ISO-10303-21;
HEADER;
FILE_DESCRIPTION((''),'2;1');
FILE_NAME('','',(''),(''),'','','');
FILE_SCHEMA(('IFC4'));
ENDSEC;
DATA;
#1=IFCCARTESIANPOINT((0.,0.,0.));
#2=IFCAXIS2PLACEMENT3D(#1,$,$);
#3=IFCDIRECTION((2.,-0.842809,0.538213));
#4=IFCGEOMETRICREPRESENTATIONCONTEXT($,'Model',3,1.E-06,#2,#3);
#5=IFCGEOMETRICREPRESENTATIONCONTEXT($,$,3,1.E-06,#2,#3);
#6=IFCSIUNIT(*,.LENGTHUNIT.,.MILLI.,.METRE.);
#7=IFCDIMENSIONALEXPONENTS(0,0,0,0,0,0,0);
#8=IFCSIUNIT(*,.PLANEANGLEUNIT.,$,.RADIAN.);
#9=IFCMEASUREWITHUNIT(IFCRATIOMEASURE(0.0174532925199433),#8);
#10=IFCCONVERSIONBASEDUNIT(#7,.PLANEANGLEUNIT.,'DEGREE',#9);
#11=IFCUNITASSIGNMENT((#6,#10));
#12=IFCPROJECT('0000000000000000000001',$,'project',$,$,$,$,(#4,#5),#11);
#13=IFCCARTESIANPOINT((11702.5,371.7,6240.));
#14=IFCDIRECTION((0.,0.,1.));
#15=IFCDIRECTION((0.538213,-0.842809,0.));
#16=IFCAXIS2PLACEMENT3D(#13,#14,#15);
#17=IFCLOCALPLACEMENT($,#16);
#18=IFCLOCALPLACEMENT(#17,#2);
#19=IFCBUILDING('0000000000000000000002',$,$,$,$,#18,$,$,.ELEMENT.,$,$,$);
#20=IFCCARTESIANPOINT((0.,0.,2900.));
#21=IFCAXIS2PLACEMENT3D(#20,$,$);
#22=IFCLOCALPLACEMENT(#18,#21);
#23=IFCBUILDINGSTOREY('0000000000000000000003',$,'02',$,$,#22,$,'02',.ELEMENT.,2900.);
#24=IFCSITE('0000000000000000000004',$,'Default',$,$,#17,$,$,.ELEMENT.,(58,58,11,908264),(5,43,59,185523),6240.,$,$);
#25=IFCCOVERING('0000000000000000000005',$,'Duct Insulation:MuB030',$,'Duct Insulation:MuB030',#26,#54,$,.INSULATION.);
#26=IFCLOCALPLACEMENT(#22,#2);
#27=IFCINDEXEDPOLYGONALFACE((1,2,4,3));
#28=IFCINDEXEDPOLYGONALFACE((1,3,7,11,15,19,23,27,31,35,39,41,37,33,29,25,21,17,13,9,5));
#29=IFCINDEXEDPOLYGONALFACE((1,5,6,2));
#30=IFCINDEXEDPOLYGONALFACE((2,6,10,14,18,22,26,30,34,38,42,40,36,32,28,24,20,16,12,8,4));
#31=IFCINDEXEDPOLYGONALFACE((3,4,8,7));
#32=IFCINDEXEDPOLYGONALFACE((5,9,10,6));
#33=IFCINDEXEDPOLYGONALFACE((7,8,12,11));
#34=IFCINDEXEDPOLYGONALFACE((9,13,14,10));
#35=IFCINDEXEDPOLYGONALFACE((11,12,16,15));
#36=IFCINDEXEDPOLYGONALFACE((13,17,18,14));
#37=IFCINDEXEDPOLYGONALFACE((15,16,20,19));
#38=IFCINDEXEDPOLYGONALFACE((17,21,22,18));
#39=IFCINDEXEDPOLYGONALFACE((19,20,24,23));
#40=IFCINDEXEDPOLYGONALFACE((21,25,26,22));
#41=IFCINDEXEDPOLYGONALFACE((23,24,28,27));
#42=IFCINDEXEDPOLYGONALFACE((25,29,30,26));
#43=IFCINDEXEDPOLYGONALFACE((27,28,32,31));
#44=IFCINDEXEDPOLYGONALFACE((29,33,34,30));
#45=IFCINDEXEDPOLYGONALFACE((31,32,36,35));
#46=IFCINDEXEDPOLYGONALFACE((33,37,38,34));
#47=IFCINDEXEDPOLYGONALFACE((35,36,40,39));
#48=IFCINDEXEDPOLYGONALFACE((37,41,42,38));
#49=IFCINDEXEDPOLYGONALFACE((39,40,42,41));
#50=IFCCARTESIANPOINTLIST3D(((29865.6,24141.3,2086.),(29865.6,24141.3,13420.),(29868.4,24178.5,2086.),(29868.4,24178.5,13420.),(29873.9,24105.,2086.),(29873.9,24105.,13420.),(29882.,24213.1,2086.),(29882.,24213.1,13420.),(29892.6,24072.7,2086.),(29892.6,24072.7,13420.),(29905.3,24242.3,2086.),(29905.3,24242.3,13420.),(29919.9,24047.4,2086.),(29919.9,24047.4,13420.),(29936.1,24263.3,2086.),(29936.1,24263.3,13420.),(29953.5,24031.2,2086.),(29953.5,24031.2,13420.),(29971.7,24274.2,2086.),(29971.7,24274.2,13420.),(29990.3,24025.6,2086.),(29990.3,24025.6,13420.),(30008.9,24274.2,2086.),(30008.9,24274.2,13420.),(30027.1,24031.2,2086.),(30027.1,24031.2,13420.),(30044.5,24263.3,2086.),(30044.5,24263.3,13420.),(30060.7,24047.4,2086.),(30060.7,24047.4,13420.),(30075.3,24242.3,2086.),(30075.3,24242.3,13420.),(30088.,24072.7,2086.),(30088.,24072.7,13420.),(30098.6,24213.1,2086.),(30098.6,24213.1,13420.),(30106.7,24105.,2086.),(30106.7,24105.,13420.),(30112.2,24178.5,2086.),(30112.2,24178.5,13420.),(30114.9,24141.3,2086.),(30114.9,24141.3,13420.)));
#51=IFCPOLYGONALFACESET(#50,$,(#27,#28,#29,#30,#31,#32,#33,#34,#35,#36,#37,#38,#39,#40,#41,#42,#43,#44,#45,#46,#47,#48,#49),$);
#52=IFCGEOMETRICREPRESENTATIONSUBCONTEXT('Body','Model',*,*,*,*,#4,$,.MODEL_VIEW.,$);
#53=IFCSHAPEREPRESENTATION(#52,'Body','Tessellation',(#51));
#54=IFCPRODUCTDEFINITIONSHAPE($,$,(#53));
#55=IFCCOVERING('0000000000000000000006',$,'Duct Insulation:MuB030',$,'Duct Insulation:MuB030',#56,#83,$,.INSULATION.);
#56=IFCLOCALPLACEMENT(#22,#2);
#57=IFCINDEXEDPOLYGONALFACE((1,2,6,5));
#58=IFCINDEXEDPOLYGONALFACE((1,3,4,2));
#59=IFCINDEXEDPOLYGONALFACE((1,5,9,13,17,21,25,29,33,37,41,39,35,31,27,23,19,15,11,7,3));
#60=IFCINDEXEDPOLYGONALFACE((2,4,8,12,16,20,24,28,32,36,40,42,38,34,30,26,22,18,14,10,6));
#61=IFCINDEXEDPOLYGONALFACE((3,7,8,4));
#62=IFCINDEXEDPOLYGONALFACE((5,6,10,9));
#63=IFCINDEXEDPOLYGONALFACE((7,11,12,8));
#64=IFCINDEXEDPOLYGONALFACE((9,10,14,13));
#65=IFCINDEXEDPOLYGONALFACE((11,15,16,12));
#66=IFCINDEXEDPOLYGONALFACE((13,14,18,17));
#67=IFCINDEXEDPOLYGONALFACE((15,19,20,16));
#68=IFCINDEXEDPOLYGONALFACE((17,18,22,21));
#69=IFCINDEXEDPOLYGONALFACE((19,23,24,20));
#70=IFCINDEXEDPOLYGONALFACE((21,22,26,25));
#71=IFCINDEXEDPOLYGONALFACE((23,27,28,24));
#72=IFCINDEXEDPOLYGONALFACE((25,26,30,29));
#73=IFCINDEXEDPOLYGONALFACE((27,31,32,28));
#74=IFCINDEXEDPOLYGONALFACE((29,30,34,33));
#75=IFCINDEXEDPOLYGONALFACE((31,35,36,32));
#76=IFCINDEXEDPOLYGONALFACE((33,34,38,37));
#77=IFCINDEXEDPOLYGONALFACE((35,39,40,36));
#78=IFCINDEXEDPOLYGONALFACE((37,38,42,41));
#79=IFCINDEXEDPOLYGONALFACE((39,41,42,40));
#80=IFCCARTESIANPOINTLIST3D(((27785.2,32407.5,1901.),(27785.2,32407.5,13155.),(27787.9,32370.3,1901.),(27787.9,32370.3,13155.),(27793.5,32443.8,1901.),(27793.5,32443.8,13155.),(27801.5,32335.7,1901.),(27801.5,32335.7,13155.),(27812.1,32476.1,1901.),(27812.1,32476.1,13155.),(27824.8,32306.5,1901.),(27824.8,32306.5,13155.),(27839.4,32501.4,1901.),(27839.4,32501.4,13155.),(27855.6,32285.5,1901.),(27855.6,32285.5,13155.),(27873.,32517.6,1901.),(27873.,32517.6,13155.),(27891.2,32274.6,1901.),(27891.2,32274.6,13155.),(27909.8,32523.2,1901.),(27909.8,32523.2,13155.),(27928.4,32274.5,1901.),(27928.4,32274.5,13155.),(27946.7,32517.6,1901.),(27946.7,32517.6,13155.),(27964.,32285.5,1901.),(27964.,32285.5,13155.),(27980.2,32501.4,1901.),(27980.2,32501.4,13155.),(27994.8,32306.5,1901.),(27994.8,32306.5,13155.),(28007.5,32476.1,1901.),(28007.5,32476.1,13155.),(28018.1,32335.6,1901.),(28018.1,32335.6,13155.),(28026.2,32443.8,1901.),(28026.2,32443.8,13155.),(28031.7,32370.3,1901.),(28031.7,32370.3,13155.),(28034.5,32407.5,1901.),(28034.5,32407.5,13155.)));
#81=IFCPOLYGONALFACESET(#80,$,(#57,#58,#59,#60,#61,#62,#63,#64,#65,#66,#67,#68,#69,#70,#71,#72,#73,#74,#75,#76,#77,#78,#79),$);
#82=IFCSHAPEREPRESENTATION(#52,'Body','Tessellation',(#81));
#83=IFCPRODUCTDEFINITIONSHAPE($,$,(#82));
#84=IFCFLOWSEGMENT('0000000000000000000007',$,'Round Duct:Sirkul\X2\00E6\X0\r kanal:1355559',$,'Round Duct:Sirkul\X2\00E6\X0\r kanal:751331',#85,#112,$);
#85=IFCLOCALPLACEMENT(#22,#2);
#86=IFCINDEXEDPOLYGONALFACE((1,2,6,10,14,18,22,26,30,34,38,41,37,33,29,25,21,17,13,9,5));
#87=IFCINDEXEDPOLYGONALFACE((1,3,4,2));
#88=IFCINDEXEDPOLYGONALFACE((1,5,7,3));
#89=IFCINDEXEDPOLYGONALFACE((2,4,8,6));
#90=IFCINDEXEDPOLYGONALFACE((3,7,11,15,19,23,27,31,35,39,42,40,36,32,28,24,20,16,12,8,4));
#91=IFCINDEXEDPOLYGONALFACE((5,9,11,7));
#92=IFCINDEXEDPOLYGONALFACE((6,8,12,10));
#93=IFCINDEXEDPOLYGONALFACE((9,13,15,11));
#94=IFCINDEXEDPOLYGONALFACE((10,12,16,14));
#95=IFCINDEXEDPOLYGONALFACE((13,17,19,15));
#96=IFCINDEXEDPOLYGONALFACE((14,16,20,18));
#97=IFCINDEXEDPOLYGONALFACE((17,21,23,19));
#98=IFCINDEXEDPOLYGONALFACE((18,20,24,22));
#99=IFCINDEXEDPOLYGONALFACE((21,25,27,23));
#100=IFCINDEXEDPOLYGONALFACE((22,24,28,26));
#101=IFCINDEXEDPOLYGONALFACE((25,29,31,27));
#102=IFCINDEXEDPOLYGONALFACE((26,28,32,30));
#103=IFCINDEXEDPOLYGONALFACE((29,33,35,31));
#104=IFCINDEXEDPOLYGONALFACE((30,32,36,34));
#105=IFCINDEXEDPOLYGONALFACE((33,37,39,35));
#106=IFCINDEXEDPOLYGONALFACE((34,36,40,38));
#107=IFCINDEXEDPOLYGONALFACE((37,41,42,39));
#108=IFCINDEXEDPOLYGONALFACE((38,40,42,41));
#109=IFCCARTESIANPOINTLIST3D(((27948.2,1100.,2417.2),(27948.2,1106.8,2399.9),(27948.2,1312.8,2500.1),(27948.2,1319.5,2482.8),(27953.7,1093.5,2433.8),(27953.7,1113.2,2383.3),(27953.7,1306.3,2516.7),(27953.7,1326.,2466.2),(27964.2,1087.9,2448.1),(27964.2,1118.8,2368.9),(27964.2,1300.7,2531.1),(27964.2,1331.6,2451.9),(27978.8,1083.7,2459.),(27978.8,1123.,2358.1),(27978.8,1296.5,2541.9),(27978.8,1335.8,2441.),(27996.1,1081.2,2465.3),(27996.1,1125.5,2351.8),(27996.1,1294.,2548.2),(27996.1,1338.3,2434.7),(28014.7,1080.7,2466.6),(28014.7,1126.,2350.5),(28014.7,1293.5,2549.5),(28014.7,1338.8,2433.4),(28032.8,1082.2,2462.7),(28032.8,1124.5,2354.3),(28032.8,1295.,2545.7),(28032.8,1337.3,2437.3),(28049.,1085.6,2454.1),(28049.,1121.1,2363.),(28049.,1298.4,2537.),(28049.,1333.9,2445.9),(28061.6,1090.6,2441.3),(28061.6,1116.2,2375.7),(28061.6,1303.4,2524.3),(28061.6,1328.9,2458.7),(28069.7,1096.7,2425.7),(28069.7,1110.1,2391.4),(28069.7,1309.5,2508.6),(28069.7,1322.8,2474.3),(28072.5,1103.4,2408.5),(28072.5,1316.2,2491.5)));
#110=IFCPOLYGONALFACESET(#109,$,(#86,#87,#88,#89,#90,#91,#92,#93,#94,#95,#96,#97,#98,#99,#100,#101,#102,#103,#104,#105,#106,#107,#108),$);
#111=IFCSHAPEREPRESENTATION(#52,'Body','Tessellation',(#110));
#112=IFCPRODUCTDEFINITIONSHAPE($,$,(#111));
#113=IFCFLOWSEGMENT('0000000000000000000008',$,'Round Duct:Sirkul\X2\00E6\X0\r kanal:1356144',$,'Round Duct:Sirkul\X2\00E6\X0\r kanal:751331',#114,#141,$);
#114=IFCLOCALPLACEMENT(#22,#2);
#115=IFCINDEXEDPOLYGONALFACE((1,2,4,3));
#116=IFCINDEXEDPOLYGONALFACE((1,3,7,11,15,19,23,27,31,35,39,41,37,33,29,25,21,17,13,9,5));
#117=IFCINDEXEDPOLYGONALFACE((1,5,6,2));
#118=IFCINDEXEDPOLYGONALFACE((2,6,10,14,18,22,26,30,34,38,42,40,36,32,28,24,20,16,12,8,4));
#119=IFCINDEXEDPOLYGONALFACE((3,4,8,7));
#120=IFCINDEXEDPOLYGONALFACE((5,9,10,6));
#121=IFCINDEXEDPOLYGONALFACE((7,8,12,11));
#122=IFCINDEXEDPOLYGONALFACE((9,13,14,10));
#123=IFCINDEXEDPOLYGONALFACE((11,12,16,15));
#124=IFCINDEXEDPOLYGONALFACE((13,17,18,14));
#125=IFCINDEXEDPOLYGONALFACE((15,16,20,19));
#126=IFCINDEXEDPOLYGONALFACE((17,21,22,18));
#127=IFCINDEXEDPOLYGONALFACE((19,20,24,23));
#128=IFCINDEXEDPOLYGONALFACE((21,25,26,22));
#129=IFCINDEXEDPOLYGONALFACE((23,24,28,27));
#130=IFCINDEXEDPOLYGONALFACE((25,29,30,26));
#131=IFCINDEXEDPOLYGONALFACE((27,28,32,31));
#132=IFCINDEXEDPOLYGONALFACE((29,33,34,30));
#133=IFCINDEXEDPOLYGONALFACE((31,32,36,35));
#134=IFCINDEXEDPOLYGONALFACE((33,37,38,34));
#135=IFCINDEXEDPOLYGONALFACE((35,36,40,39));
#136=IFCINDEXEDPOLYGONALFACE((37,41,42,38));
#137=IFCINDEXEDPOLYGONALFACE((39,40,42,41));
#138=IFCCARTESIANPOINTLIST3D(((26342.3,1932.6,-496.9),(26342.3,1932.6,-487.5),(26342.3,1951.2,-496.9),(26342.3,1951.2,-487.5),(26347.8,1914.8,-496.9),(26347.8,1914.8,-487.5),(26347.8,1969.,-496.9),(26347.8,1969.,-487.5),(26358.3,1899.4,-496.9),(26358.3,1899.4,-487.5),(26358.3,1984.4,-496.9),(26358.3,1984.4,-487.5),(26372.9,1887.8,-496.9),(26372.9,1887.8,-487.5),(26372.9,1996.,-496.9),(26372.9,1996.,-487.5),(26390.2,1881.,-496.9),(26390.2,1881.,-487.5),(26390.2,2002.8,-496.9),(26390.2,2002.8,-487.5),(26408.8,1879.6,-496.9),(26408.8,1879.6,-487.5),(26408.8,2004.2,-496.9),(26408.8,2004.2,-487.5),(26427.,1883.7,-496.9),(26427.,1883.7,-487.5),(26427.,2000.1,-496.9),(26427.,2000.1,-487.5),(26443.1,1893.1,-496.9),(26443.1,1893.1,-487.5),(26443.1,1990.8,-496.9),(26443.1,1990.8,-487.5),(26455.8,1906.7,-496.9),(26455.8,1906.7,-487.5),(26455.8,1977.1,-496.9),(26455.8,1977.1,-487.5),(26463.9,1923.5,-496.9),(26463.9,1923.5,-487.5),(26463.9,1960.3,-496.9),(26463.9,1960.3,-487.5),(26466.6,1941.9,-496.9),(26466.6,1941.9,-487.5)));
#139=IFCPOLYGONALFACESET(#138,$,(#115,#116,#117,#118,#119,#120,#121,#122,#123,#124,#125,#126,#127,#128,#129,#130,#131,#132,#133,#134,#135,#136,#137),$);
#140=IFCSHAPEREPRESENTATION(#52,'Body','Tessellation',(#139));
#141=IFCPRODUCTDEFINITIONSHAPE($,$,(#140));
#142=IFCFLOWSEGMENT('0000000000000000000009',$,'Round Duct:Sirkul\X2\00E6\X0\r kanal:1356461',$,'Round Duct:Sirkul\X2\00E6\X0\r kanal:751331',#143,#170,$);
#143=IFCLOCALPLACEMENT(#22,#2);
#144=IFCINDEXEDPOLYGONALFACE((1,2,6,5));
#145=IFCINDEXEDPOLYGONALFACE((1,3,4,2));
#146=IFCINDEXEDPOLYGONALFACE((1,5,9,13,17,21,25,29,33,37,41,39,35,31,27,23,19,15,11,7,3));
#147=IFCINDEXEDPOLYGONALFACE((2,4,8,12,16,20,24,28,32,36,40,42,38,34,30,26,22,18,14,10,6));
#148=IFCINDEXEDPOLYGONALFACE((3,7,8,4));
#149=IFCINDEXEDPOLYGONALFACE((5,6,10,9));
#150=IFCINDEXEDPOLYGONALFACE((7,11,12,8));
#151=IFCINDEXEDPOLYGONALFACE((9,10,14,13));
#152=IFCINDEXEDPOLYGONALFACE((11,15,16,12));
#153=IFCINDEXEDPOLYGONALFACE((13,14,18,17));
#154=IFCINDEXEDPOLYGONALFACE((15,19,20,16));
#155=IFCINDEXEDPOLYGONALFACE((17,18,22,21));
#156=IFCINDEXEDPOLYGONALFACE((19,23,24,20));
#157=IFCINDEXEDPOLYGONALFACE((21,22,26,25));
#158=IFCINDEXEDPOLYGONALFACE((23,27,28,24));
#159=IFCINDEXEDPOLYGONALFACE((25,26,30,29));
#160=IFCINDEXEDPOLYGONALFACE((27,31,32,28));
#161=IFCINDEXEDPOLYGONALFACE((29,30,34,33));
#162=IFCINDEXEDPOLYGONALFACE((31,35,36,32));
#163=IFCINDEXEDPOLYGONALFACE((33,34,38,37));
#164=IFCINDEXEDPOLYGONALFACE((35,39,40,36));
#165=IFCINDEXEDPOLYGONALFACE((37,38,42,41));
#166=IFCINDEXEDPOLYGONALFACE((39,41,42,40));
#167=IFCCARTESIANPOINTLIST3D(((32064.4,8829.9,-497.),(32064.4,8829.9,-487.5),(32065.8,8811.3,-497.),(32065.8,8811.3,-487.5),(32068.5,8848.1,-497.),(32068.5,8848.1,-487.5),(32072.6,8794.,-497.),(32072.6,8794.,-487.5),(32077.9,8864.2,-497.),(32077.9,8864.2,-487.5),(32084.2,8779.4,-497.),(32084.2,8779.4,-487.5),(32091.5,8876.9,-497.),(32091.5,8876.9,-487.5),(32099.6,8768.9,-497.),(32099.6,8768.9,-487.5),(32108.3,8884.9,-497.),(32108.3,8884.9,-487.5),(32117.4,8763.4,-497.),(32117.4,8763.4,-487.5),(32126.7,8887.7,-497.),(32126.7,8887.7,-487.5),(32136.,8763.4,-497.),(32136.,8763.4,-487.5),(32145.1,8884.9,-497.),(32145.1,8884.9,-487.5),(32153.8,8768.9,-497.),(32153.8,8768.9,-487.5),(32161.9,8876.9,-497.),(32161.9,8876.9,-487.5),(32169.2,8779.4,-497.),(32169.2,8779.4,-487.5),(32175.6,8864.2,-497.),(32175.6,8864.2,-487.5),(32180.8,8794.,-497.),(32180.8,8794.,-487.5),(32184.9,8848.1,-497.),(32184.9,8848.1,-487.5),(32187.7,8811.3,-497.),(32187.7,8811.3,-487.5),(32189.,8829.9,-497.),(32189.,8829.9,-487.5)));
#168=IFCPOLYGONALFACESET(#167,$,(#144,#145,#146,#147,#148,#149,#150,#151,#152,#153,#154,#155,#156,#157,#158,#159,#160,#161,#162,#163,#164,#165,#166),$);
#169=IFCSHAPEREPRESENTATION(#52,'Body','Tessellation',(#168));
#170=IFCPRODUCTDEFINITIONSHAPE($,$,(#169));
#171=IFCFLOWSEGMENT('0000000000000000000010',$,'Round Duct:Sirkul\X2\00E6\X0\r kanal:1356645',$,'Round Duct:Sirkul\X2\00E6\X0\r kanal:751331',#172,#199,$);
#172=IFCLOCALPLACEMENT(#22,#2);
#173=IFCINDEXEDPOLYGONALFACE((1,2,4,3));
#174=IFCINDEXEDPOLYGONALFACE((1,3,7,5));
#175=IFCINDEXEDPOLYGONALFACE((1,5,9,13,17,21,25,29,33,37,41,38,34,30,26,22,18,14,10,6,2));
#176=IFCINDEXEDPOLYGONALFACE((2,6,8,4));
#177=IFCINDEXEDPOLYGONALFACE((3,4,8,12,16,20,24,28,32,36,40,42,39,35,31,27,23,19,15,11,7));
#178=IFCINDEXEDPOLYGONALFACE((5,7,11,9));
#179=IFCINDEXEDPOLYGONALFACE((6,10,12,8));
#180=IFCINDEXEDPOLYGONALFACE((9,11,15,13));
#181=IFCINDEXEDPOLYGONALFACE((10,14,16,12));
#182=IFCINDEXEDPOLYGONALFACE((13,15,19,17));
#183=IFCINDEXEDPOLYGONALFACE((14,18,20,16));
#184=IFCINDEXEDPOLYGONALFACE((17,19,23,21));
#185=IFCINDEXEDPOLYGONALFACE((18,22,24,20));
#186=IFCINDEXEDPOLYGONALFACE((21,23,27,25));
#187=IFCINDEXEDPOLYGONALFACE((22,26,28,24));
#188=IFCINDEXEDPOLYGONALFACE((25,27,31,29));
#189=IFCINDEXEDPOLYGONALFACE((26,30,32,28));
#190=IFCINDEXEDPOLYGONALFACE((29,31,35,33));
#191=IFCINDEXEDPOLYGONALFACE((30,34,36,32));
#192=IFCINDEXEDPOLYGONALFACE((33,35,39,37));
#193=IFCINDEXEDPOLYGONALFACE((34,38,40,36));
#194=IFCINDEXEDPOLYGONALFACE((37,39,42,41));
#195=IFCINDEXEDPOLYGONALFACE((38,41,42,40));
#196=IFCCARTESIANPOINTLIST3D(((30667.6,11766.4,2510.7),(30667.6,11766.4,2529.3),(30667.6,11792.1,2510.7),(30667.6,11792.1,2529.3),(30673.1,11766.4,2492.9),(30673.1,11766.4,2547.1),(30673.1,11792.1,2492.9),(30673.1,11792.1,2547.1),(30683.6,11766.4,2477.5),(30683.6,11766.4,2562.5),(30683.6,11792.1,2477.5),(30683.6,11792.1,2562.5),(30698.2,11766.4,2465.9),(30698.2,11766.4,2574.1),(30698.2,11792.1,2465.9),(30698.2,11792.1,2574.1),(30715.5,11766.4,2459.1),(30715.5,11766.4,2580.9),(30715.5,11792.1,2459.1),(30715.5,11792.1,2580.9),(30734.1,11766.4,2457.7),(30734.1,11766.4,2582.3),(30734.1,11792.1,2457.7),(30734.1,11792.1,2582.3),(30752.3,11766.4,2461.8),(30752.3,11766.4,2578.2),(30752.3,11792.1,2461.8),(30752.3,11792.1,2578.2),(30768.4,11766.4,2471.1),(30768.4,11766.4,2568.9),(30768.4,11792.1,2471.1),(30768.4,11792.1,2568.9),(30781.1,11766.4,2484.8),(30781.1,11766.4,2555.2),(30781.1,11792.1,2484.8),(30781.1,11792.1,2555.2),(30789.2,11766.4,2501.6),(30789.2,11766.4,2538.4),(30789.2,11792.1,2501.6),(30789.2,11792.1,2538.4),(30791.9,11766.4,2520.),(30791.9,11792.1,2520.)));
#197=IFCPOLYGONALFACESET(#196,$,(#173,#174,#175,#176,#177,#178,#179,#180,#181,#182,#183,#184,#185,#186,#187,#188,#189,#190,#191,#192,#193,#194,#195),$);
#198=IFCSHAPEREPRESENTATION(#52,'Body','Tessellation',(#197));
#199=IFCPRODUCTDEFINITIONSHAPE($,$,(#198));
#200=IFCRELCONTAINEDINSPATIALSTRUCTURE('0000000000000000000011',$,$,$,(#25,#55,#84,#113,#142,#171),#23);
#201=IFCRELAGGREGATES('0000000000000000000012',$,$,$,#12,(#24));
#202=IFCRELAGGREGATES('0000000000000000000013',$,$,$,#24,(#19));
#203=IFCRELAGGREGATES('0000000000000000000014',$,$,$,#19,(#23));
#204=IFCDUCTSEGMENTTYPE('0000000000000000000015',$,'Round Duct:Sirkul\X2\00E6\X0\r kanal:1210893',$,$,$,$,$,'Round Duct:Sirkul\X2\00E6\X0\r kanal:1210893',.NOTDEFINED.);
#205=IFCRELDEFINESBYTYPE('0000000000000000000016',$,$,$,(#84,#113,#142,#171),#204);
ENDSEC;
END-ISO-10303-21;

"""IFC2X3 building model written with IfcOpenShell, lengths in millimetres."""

from ifc_helpers import new_model, entity, si_unit, converted_unit, direction, frame, frame_2d, origin, origin_2d_with_axis, place, context, subcontext, project, spatial, circle, extrude, type_object, element, save


model = new_model("IFC2X3")

# Units and contexts
model_context = context("Model", 3, precision=1e-06, world=origin(), true_north=direction((2.0, -0.842809, 0.538213)))
context_of_model = context(None, 3, precision=1e-06, world=origin(), true_north=direction((2.0, -0.842809, 0.538213)))
body_context = subcontext(model_context, "Body", "Model", "MODEL_VIEW")
ifc_project = project(units=[si_unit("LENGTHUNIT", "METRE", prefix="MILLI"), converted_unit("PLANEANGLEUNIT", "DEGREE", entity("IfcRatioMeasure", 0.0174532925199433), si_unit("PLANEANGLEUNIT", "RADIAN"), dimensions=[0, 0, 0, 0, 0, 0, 0])], contexts=[model_context, context_of_model])

# Site, building, storey
site_placement = place(None, frame((11702.5, 371.7, 6240.0), z_axis=(0.0, 0.0, 1.0), x_axis=(0.538213, -0.842809, 0.0)))
site = spatial("IfcSite", under=ifc_project, at=site_placement, Name="Default", CompositionType="ELEMENT", RefLatitude=(58, 58, 11, 908264), RefLongitude=(5, 43, 59, 185523), RefElevation=6240.0)
building_placement = place(site_placement, origin())
building = spatial("IfcBuilding", under=site, at=building_placement, CompositionType="ELEMENT")
storey_placement = place(building_placement, frame((0.0, 0.0, 2900.0)))
storey = spatial("IfcBuildingStorey", under=building, at=storey_placement, Name="02", LongName="02", CompositionType="ELEMENT", Elevation=2900.0)

# Coverings
covering_1_placement = place(storey_placement, origin())
element("IfcCovering", 1, at=covering_1_placement, inside=storey, Name="Duct Insulation:MuB030", ObjectType="Duct Insulation:MuB030", PredefinedType="INSULATION", context=body_context, shape_type="SweptSolid", body=[
    extrude(circle(Radius=125.0, at=origin_2d_with_axis()), frame((29990.3, 24150.6, 2086.0), z_axis=(0.0, 0.0, 1.0), x_axis=(0.0, -1.0, 0.0)), (0.0, 0.0, 1.0), 11334.0),
])
covering_2_placement = place(storey_placement, origin())
element("IfcCovering", 2, at=covering_2_placement, inside=storey, Name="Duct Insulation:MuB030", ObjectType="Duct Insulation:MuB030", PredefinedType="INSULATION", context=body_context, shape_type="SweptSolid", body=[
    extrude(circle(Radius=125.0, at=frame_2d((0.0, 0.0), x_axis=(1.0, 0.0))), frame((27909.8, 32398.2, 1901.0), z_axis=(0.0, 0.0, 1.0), x_axis=(0.000073, 1.0, 0.0)), (0.0, 0.0, 1.0), 11254.0),
])

# Flow segments
duct_segment_type = type_object("IfcDuctSegmentType", Name="Round Duct:Sirkulær kanal:1210893", ElementType="Round Duct:Sirkulær kanal:1210893", PredefinedType="NOTDEFINED")
flow_segment_1_placement = place(storey_placement, origin())
element("IfcFlowSegment", 3, at=flow_segment_1_placement, inside=storey, type_object=duct_segment_type, Name="Round Duct:Sirkulær kanal:1355559", ObjectType="Round Duct:Sirkulær kanal:751331", context=body_context, shape_type="SweptSolid", body=[
    extrude(circle(Radius=62.5, at=origin_2d_with_axis()), frame((28010.0, 1103.4, 2408.5), z_axis=(0.0, 0.931734, 0.363142), x_axis=(1.0, 0.0, 0.0)), (0.0, 0.0, 1.0), 228.4),
])
flow_segment_2_placement = place(storey_placement, origin())
element("IfcFlowSegment", 4, at=flow_segment_2_placement, inside=storey, type_object=duct_segment_type, Name="Round Duct:Sirkulær kanal:1356144", ObjectType="Round Duct:Sirkulær kanal:751331", context=body_context, shape_type="SweptSolid", body=[
    extrude(circle(Radius=62.5, at=frame_2d((0.0, 0.0), x_axis=(1.0, 0.0))), frame((26404.1, 1941.9, -496.9)), (0.0, 0.0, 1.0), 9.4),
])
flow_segment_3_placement = place(storey_placement, origin())
element("IfcFlowSegment", 5, at=flow_segment_3_placement, inside=storey, type_object=duct_segment_type, Name="Round Duct:Sirkulær kanal:1356461", ObjectType="Round Duct:Sirkulær kanal:751331", context=body_context, shape_type="SweptSolid", body=[
    extrude(circle(Radius=62.5, at=origin_2d_with_axis()), frame((32126.7, 8825.2, -497.0), z_axis=(0.0, 0.0, 1.0), x_axis=(0.0, 1.0, 0.0)), (0.0, 0.0, 1.0), 9.5),
])
flow_segment_4_placement = place(storey_placement, origin())
element("IfcFlowSegment", 6, at=flow_segment_4_placement, inside=storey, type_object=duct_segment_type, Name="Round Duct:Sirkulær kanal:1356645", ObjectType="Round Duct:Sirkulær kanal:751331", context=body_context, shape_type="SweptSolid", body=[
    extrude(circle(Radius=62.5, at=origin_2d_with_axis()), frame((30729.4, 11766.4, 2520.0), z_axis=(0.0, 1.0, 0.0), x_axis=(1.0, 0.0, 0.0)), (0.0, 0.0, 1.0), 25.7),
])

save(model, "model.ifc")
